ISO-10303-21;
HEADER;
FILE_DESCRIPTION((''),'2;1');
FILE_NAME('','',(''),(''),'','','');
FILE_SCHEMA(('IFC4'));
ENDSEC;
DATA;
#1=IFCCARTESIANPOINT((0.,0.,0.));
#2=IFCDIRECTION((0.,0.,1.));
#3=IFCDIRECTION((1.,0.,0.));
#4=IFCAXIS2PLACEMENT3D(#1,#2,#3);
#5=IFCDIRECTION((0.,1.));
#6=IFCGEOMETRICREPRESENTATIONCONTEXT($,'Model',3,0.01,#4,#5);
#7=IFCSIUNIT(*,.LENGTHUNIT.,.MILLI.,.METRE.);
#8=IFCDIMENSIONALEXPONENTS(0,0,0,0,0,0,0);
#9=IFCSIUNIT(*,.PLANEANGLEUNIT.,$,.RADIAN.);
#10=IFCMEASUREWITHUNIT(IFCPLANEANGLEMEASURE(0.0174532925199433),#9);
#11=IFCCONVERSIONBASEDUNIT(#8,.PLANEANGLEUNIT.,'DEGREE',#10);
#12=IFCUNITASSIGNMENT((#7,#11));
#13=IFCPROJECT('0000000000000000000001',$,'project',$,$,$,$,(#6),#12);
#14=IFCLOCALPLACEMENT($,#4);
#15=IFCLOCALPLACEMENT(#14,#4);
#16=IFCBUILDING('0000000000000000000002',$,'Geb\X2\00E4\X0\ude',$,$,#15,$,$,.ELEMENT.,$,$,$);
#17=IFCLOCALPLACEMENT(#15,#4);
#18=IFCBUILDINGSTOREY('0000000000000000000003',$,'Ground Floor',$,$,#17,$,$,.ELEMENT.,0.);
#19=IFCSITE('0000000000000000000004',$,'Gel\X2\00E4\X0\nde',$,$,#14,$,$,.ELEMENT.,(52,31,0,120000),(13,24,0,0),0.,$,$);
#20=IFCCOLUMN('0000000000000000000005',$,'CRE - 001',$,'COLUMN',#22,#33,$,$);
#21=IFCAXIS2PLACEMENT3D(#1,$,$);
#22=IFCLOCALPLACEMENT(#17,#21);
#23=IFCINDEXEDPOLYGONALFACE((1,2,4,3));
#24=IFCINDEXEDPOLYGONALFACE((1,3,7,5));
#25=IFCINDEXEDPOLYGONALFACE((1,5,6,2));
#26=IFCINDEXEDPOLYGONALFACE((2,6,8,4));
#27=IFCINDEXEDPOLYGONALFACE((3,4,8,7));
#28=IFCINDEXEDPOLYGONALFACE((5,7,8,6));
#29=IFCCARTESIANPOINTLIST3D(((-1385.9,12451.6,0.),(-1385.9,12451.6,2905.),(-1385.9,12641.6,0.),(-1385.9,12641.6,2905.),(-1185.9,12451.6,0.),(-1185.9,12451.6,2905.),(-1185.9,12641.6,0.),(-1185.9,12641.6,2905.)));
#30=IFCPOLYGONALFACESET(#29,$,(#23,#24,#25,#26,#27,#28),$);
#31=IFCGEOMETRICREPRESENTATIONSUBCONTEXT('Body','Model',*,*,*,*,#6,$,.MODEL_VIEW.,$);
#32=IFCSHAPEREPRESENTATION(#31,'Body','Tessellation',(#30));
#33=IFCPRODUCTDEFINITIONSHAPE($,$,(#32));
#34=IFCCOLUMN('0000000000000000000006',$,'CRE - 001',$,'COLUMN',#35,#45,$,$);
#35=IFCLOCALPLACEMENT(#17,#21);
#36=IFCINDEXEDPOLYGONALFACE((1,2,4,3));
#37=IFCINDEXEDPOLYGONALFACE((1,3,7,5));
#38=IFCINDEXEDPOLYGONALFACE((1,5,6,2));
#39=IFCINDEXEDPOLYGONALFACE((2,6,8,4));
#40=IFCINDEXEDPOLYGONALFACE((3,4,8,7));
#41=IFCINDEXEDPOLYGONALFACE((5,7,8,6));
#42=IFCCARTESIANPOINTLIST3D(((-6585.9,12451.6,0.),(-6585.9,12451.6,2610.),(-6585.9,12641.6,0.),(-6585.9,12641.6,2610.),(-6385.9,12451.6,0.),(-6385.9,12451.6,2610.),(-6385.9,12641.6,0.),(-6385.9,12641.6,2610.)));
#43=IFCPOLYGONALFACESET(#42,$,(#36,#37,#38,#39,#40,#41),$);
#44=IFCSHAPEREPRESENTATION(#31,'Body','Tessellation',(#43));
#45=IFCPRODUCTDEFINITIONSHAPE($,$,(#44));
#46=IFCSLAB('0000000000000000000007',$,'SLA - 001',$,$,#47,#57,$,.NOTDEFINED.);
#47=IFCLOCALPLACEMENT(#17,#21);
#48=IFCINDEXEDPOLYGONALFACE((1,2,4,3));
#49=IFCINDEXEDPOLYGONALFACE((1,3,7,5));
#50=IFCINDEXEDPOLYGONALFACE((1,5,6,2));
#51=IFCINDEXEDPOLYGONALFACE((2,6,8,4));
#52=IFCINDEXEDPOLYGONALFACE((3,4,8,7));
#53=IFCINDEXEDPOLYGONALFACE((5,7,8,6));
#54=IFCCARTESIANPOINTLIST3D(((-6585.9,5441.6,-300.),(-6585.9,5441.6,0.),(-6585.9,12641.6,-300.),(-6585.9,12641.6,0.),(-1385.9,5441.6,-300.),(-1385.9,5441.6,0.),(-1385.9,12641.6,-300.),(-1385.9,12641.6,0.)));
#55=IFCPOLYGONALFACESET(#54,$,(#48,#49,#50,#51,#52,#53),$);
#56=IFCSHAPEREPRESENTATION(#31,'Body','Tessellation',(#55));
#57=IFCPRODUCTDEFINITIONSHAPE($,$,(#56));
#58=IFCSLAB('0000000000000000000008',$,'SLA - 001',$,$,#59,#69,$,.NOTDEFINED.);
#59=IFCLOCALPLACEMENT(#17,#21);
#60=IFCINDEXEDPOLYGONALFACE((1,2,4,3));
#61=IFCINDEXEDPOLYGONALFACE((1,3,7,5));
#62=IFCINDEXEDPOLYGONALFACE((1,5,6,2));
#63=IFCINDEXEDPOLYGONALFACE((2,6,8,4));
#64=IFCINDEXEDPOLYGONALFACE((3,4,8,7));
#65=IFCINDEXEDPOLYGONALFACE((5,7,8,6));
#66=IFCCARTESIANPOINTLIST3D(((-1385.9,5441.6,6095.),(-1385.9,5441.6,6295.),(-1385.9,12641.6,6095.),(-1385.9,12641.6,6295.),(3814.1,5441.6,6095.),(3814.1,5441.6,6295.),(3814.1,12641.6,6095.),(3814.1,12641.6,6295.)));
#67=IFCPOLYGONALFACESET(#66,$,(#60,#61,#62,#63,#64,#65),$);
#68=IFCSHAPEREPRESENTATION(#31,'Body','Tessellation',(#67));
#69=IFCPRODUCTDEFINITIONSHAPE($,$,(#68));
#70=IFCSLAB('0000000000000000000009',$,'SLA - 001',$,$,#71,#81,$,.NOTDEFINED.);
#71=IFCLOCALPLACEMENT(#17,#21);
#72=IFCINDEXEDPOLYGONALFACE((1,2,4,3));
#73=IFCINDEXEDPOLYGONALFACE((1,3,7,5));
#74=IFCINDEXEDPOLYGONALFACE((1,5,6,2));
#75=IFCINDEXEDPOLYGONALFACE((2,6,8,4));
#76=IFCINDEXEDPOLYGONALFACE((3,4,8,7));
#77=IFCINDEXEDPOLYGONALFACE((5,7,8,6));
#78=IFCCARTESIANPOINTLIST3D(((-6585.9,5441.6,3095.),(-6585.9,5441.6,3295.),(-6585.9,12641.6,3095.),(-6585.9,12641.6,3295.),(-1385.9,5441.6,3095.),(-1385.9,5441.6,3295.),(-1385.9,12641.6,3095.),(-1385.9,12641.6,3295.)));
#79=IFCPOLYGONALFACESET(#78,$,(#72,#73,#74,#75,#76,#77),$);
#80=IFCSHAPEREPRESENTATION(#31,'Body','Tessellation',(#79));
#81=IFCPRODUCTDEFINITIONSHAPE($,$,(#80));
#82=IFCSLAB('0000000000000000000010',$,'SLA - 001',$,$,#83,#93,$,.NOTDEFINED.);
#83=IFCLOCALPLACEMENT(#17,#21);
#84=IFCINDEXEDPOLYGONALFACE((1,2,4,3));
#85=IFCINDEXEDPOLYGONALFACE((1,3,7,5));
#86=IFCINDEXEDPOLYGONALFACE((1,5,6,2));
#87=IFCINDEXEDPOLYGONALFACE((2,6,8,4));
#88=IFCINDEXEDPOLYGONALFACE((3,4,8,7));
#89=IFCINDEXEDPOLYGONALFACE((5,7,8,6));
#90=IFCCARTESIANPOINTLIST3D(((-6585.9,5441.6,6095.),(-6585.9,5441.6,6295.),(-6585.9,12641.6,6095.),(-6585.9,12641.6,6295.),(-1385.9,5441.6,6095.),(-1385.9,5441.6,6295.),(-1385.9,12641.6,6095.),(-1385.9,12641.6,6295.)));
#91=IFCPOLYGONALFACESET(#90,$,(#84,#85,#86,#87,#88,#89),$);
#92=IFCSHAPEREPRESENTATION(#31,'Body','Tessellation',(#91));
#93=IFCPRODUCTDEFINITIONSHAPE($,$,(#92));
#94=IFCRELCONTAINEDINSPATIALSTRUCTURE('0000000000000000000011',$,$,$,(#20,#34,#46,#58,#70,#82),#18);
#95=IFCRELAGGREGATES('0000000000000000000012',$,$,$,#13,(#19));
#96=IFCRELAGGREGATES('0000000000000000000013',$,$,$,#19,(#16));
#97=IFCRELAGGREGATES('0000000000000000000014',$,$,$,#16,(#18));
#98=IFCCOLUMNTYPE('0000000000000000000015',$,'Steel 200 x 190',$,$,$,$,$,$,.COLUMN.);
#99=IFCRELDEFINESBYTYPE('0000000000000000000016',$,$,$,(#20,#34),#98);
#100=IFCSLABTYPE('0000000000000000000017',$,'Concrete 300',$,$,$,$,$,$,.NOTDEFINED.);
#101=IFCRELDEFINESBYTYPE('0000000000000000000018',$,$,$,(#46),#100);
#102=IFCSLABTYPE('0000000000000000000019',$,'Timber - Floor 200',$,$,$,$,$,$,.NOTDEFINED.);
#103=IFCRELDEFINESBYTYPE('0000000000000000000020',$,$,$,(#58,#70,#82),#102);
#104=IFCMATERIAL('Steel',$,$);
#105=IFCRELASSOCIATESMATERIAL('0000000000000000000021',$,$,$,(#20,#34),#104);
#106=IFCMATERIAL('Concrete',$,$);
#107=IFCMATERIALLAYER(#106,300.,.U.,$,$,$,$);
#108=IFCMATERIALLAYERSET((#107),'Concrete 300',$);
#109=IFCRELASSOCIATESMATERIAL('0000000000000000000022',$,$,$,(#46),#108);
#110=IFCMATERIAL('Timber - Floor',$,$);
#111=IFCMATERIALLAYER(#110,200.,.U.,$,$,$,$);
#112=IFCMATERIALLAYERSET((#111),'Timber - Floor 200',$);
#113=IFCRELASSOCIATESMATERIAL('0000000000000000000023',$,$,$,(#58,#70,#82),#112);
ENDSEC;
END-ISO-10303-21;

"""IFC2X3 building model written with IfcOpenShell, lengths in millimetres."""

from ifc_helpers import new_model, entity, si_unit, converted_unit, direction, frame, origin_with_axes, origin_2d_with_axis, place, context, subcontext, project, spatial, polyline, rectangle, outline, extrude, material, layer, layer_set, layer_usage, type_object, element, save


model = new_model("IFC2X3")

# Units and contexts
model_context = context("Model", 3, precision=0.01, world=origin_with_axes(), true_north=direction((0.0, 1.0)))
body_context = subcontext(model_context, "Body", "Model", "MODEL_VIEW")
ifc_project = project(units=[si_unit("LENGTHUNIT", "METRE", prefix="MILLI"), converted_unit("PLANEANGLEUNIT", "DEGREE", entity("IfcPlaneAngleMeasure", 0.0174532925199433), si_unit("PLANEANGLEUNIT", "RADIAN"), dimensions=[0, 0, 0, 0, 0, 0, 0])], contexts=[model_context])

# Site, building, storey
site_placement = place(None, origin_with_axes())
site = spatial("IfcSite", under=ifc_project, at=site_placement, Name="Gelände", CompositionType="ELEMENT", RefLatitude=(52, 31, 0, 120000), RefLongitude=(13, 24, 0, 0), RefElevation=0.0)
building_placement = place(site_placement, origin_with_axes())
building = spatial("IfcBuilding", under=site, at=building_placement, Name="Gebäude", CompositionType="ELEMENT")
storey_placement = place(building_placement, origin_with_axes())
storey = spatial("IfcBuildingStorey", under=building, at=storey_placement, Name="Ground Floor", CompositionType="ELEMENT", Elevation=0.0)

# Columns
ifc_material_1 = material(Name="Steel")
column_type_1 = type_object("IfcColumnType", Name="Steel 200 x 190", PredefinedType="COLUMN")
column_1_placement = place(storey_placement, frame((-1285.9, 12546.6, 0.0), z_axis=(0.0, 0.0, 1.0), x_axis=(1.0, 0.0, 0.0)))
element("IfcColumn", 1, at=column_1_placement, inside=storey, type_object=column_type_1, material=ifc_material_1, Name="CRE - 001", ObjectType="COLUMN", context=body_context, shape_type="SweptSolid", body=[
    extrude(rectangle(XDim=200.0, YDim=190.0, at=origin_2d_with_axis()), origin_with_axes(), (0.0, 0.0, 1.0), 2905.0),
])
column_2_placement = place(storey_placement, frame((-6485.9, 12546.6, 0.0), z_axis=(0.0, 0.0, 1.0), x_axis=(1.0, 0.0, 0.0)))
element("IfcColumn", 2, at=column_2_placement, inside=storey, type_object=column_type_1, material=ifc_material_1, Name="CRE - 001", ObjectType="COLUMN", context=body_context, shape_type="SweptSolid", body=[
    extrude(rectangle(XDim=200.0, YDim=190.0, at=origin_2d_with_axis()), origin_with_axes(), (0.0, 0.0, 1.0), 2610.0),
])

# Slabs
ifc_material_2 = material(Name="Concrete")
ifc_layer_1 = layer(ifc_material_2, 300.0, ventilated="UNKNOWN")
ifc_layer_set_1 = layer_set([ifc_layer_1], Name="Concrete 300")
ifc_layer_usage_1 = layer_usage(ifc_layer_set_1, "AXIS3", "NEGATIVE", 300.0)
slab_type_1 = type_object("IfcSlabType", Name="Concrete 300", PredefinedType="NOTDEFINED")
slab_1_placement = place(storey_placement, frame((-6585.9, 5441.6, 0.0), z_axis=(0.0, 0.0, 1.0), x_axis=(1.0, 0.0, 0.0)))
element("IfcSlab", 3, at=slab_1_placement, inside=storey, type_object=slab_type_1, material=ifc_layer_usage_1, Name="SLA - 001", PredefinedType="NOTDEFINED", context=body_context, shape_type="SweptSolid", body=[
    extrude(outline(polyline([(0.0, 0.0), (5200.0, 0.0), (5200.0, 7200.0), (0.0, 7200.0), (0.0, 0.0)])), frame((0.0, 0.0, -300.0), z_axis=(0.0, 0.0, 1.0), x_axis=(1.0, 0.0, 0.0)), (0.0, 0.0, 1.0), 300.0),
])
ifc_material_3 = material(Name="Timber - Floor")
ifc_layer_2 = layer(ifc_material_3, 200.0, ventilated="UNKNOWN")
ifc_layer_set_2 = layer_set([ifc_layer_2], Name="Timber - Floor 200")
ifc_layer_usage_2 = layer_usage(ifc_layer_set_2, "AXIS3", "NEGATIVE", 200.0)
slab_type_2 = type_object("IfcSlabType", Name="Timber - Floor 200", PredefinedType="NOTDEFINED")
slab_2_placement = place(storey_placement, frame((-1385.9, 5441.6, 6295.0), z_axis=(0.0, 0.0, 1.0), x_axis=(1.0, 0.0, 0.0)))
element("IfcSlab", 4, at=slab_2_placement, inside=storey, type_object=slab_type_2, material=ifc_layer_usage_2, Name="SLA - 001", PredefinedType="NOTDEFINED", context=body_context, shape_type="SweptSolid", body=[
    extrude(outline(polyline([(0.0, 0.0), (5200.0, 0.0), (5200.0, 7200.0), (0.0, 7200.0), (0.0, 0.0)])), frame((0.0, 0.0, -200.0), z_axis=(0.0, 0.0, 1.0), x_axis=(1.0, 0.0, 0.0)), (0.0, 0.0, 1.0), 200.0),
])
ifc_layer_usage_3 = layer_usage(ifc_layer_set_2, "AXIS3", "NEGATIVE", 200.0)
slab_3_placement = place(storey_placement, frame((-6585.9, 5441.6, 3295.0), z_axis=(0.0, 0.0, 1.0), x_axis=(1.0, 0.0, 0.0)))
element("IfcSlab", 5, at=slab_3_placement, inside=storey, type_object=slab_type_2, material=ifc_layer_usage_3, Name="SLA - 001", PredefinedType="NOTDEFINED", context=body_context, shape_type="SweptSolid", body=[
    extrude(outline(polyline([(0.0, 0.0), (5200.0, 0.0), (5200.0, 7200.0), (0.0, 7200.0), (0.0, 0.0)])), frame((0.0, 0.0, -200.0), z_axis=(0.0, 0.0, 1.0), x_axis=(1.0, 0.0, 0.0)), (0.0, 0.0, 1.0), 200.0),
])
ifc_layer_usage_4 = layer_usage(ifc_layer_set_2, "AXIS3", "NEGATIVE", 200.0)
slab_4_placement = place(storey_placement, frame((-6585.9, 5441.6, 6295.0), z_axis=(0.0, 0.0, 1.0), x_axis=(1.0, 0.0, 0.0)))
element("IfcSlab", 6, at=slab_4_placement, inside=storey, type_object=slab_type_2, material=ifc_layer_usage_4, Name="SLA - 001", PredefinedType="NOTDEFINED", context=body_context, shape_type="SweptSolid", body=[
    extrude(outline(polyline([(0.0, 0.0), (5200.0, 0.0), (5200.0, 7200.0), (0.0, 7200.0), (0.0, 0.0)])), frame((0.0, 0.0, -200.0), z_axis=(0.0, 0.0, 1.0), x_axis=(1.0, 0.0, 0.0)), (0.0, 0.0, 1.0), 200.0),
])

save(model, "model.ifc")
